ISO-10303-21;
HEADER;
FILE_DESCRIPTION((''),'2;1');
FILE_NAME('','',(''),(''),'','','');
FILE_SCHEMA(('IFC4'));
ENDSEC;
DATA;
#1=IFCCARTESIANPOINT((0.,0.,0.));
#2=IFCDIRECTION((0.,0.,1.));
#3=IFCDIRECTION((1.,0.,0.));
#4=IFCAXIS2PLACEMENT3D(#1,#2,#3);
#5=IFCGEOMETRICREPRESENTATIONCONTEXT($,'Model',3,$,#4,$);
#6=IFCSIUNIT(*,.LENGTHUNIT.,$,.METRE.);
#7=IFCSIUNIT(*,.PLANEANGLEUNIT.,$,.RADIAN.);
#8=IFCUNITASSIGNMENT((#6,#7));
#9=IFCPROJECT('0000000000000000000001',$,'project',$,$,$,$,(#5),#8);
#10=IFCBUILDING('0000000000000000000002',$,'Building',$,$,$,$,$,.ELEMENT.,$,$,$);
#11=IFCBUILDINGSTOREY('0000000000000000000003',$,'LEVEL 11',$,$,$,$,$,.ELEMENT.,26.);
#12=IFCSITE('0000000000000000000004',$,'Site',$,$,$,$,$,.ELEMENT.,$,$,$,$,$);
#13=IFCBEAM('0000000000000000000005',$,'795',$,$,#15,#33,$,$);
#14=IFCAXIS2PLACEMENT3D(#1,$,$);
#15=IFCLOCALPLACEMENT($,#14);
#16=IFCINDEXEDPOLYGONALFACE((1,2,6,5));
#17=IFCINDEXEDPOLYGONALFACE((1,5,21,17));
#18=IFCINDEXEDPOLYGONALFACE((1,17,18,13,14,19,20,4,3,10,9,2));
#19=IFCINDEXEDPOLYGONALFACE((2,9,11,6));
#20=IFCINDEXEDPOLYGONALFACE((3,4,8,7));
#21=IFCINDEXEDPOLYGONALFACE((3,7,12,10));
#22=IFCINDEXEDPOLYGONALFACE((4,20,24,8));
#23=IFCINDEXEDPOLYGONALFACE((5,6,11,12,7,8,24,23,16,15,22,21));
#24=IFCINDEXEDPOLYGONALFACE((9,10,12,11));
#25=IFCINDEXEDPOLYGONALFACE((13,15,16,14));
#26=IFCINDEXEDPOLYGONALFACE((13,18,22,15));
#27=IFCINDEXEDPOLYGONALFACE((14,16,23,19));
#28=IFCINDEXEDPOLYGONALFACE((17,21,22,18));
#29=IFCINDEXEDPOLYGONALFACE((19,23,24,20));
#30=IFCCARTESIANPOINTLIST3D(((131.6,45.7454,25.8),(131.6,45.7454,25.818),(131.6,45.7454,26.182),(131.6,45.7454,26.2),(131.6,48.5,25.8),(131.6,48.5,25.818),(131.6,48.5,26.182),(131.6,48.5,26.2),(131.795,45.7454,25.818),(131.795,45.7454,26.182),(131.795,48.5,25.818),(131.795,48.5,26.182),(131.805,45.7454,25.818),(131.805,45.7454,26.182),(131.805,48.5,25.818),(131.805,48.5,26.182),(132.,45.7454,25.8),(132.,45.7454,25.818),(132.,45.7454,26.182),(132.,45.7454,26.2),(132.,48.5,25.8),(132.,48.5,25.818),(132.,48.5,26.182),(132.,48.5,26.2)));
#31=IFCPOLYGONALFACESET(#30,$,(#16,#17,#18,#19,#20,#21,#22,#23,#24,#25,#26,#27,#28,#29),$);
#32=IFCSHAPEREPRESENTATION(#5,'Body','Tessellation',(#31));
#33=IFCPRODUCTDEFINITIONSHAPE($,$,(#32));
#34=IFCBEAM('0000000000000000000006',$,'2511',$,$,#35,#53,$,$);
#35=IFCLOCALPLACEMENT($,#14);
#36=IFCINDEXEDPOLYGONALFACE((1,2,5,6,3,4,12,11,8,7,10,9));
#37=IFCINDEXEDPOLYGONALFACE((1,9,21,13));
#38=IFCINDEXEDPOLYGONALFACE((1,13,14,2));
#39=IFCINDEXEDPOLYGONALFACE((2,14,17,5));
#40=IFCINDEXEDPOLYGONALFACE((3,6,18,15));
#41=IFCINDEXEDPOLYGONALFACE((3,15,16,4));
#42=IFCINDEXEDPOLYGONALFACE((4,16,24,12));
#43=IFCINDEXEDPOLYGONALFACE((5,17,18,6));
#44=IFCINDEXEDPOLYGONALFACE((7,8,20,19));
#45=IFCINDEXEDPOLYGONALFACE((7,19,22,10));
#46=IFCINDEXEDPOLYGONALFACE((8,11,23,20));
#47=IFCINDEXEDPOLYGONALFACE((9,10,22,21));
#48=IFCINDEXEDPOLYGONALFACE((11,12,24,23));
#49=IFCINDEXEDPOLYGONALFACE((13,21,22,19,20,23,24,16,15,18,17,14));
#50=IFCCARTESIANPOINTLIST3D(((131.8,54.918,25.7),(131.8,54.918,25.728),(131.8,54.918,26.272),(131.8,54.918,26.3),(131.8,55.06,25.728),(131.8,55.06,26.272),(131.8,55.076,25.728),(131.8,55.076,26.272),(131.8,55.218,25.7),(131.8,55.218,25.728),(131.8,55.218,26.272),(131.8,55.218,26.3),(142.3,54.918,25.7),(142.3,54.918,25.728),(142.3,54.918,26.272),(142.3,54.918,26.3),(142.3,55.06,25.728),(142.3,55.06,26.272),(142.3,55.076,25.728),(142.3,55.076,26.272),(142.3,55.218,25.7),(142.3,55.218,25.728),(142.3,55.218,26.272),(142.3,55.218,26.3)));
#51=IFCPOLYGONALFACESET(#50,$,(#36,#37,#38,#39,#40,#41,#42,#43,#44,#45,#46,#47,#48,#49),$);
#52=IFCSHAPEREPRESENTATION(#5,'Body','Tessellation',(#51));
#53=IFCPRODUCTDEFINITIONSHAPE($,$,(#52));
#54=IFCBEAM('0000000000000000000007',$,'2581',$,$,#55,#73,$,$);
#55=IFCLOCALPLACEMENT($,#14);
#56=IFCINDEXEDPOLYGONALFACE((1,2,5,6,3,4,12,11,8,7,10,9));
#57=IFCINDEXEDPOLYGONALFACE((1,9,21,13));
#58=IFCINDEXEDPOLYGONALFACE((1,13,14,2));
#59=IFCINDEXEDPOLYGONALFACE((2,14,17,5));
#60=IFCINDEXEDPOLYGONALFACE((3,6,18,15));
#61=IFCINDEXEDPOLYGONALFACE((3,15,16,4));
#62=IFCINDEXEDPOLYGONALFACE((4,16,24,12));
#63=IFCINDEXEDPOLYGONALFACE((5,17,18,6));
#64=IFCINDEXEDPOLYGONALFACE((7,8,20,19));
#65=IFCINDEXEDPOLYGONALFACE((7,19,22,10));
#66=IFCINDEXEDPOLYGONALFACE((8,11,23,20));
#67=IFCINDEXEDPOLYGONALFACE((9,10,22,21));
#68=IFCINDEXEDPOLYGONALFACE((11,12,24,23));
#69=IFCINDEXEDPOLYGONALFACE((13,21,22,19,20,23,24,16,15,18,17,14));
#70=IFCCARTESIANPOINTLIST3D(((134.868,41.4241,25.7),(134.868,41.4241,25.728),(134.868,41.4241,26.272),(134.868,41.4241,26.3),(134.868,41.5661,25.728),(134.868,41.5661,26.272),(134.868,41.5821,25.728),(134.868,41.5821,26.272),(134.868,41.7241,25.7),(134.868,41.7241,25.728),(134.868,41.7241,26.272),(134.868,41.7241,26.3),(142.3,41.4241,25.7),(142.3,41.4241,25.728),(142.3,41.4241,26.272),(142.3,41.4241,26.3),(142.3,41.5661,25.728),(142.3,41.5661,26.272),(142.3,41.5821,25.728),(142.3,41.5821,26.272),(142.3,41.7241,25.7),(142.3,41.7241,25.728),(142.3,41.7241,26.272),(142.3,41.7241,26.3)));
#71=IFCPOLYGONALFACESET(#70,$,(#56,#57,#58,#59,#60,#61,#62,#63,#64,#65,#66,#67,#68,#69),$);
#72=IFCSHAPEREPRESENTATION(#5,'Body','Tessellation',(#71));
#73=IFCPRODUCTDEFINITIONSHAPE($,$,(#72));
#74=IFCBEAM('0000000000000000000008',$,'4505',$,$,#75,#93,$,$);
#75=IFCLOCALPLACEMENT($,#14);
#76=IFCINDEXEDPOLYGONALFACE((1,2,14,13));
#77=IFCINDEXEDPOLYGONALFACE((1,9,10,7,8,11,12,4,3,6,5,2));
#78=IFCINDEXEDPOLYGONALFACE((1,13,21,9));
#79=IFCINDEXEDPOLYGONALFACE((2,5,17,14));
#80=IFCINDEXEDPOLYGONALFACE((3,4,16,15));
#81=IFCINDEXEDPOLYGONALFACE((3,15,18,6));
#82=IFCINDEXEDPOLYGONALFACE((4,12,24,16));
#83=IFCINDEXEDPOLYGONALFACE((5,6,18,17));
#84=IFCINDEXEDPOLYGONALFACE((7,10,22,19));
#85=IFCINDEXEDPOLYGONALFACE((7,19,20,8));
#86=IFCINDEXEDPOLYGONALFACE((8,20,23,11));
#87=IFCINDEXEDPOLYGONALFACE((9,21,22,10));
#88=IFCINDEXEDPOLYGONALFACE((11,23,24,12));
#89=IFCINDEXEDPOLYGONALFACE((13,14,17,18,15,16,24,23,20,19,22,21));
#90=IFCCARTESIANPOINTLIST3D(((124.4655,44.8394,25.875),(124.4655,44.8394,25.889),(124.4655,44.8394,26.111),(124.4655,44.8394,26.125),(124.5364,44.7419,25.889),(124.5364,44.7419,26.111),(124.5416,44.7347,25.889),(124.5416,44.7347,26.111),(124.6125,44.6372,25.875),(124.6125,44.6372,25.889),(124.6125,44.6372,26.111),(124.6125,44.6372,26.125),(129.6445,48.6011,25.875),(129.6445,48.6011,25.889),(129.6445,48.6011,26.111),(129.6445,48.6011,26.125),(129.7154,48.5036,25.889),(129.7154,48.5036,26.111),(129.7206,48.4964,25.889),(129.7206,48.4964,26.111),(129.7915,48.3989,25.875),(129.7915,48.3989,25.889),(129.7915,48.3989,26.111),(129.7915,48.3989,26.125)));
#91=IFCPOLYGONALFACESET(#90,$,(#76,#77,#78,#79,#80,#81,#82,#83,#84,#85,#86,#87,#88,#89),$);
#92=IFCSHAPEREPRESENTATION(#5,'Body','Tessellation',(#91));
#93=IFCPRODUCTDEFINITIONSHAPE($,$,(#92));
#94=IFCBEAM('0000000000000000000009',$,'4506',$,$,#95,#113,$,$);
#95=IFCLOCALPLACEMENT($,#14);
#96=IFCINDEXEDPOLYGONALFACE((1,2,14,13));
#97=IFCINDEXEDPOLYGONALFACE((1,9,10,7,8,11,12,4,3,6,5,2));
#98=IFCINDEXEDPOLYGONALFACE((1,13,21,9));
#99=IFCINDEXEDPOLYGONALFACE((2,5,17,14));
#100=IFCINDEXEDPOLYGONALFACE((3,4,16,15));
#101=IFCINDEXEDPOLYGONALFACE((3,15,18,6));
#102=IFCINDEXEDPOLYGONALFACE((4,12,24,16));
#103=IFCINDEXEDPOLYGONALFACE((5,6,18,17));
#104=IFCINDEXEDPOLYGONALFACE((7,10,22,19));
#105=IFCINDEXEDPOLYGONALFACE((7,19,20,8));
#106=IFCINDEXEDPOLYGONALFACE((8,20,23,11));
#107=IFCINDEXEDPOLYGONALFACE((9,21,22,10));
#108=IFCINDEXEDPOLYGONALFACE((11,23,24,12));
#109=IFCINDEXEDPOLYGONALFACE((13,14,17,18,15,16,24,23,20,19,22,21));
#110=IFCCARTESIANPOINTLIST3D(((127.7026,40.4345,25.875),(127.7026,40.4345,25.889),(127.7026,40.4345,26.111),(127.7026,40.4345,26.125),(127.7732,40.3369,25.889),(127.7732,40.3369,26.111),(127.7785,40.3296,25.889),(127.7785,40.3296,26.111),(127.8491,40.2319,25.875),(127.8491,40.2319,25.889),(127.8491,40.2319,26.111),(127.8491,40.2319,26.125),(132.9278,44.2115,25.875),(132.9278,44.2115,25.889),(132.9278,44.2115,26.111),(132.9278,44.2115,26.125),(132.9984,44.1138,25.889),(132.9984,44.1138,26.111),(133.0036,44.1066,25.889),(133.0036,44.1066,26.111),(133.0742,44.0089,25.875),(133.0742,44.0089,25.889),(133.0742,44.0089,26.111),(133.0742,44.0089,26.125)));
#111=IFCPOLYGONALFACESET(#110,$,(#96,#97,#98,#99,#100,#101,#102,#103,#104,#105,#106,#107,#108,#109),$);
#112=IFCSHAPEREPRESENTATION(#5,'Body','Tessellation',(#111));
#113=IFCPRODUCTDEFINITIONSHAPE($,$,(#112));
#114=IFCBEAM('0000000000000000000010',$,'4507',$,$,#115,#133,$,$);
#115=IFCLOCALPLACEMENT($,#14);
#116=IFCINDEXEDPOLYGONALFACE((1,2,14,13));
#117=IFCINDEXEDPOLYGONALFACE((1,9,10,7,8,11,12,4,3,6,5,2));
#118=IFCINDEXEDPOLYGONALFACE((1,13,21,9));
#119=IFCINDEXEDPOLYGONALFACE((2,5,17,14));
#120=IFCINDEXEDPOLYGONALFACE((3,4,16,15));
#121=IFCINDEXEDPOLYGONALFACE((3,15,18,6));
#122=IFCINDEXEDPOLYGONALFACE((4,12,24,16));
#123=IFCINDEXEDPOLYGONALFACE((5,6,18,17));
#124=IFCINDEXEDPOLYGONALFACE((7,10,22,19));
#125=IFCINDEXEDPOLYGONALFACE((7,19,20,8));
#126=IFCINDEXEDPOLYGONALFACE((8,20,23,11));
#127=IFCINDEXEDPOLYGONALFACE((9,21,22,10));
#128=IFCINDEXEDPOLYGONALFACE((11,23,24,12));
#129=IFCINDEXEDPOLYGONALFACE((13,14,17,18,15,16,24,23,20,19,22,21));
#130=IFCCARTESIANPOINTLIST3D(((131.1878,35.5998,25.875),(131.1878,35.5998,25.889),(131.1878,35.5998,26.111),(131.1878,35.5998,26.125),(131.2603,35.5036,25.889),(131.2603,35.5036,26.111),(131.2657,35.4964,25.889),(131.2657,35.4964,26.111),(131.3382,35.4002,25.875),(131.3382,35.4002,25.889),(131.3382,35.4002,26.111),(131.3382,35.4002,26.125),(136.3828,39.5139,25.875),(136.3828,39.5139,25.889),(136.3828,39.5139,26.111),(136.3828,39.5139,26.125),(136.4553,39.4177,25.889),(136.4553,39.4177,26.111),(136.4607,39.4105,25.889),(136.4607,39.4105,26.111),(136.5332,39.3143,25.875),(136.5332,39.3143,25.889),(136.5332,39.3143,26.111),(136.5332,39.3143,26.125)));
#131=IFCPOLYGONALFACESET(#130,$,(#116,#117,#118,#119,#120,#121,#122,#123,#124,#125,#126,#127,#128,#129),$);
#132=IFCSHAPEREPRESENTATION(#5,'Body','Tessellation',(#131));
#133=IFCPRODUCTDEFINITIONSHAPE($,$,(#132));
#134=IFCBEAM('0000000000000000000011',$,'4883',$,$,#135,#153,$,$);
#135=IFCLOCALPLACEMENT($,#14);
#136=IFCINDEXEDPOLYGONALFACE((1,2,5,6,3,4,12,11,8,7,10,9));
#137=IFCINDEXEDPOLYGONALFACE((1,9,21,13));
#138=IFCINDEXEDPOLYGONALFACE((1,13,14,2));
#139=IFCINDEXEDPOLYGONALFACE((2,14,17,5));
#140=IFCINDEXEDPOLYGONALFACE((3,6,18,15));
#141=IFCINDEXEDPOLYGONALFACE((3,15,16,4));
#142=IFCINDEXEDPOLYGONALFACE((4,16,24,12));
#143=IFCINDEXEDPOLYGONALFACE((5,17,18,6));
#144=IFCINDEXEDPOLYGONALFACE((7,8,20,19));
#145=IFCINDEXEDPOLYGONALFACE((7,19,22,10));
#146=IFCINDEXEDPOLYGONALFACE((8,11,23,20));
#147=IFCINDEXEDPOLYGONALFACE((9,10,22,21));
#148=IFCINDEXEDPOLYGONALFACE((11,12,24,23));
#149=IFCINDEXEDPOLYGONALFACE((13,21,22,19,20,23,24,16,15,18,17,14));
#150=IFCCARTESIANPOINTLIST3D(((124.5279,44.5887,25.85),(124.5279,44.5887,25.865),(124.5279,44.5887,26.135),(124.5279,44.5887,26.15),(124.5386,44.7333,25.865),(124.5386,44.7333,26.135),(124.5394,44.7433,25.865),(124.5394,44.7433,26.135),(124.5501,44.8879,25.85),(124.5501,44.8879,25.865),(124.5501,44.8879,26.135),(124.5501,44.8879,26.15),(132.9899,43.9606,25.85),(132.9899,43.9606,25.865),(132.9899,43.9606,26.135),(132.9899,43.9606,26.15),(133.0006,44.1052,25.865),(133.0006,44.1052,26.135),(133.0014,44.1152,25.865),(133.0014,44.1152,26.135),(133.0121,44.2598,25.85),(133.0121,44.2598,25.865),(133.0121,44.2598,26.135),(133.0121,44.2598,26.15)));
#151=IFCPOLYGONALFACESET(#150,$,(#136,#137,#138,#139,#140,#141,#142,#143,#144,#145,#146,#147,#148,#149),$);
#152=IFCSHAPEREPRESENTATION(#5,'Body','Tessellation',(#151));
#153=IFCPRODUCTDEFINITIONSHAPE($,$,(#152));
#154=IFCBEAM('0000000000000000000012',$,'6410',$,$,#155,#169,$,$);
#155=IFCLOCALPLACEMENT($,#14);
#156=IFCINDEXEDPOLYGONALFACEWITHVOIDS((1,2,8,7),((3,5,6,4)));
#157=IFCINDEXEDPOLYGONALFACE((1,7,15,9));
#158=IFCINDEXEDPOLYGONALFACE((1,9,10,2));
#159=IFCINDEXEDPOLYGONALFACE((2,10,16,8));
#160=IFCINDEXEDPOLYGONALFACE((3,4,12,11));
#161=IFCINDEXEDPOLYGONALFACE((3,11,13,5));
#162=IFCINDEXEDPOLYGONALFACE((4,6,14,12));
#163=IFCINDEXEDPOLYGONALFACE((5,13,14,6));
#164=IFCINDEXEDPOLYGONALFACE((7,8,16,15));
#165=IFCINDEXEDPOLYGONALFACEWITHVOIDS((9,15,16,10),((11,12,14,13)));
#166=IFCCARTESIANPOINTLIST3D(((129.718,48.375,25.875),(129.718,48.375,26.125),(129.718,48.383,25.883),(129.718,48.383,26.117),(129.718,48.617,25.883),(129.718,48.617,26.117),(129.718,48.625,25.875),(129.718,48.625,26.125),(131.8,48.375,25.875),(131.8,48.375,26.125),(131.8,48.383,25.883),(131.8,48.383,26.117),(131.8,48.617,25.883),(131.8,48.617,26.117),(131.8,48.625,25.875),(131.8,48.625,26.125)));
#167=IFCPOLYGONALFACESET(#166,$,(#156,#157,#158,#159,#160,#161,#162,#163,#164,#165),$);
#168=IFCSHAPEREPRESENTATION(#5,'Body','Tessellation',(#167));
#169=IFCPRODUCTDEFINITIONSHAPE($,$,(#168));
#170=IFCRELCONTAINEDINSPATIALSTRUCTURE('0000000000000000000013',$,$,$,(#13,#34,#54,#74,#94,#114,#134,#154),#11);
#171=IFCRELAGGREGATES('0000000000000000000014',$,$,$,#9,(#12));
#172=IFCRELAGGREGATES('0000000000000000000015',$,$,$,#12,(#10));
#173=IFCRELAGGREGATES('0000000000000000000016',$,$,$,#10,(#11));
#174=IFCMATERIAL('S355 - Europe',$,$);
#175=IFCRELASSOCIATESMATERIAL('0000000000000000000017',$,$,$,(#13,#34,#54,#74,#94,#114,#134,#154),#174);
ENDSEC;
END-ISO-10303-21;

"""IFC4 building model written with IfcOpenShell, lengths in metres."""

from ifc_helpers import new_model, si_unit, frame, origin_with_axes, origin_2d_with_axis, place, context, project, spatial, hollow_rectangle, i_section, extrude, material, material_profile, profile_set, profile_usage, element, save


model = new_model("IFC4")

# Units and contexts
model_context = context("Model", 3, world=origin_with_axes())
ifc_project = project(units=[si_unit("LENGTHUNIT", "METRE"), si_unit("PLANEANGLEUNIT", "RADIAN")], contexts=[model_context])

# Site, building, storey
site = spatial("IfcSite", under=ifc_project, Name="Site", CompositionType="ELEMENT")
building = spatial("IfcBuilding", under=site, Name="Building", CompositionType="ELEMENT")
storey = spatial("IfcBuildingStorey", under=building, Name="LEVEL 11", CompositionType="ELEMENT", Elevation=26.0)

# Shared definitions
ifc_material = material(Name="S355 - Europe")

# Beams
ifc_material_profile_1 = material_profile(ifc_material, i_section(OverallWidth=0.4, OverallDepth=0.4, WebThickness=0.01, FlangeThickness=0.018, at=origin_2d_with_axis()))
ifc_profile_set_1 = profile_set([ifc_material_profile_1])
ifc_profile_usage_1 = profile_usage(ifc_profile_set_1, cardinal=10)
beam_1_placement = place(None, frame((131.8, 45.7454, 26.0), z_axis=(0.0, 1.0, 0.0), x_axis=(-1.0, 0.0, 0.0)))
element("IfcBeam", 1, at=beam_1_placement, inside=storey, material=ifc_profile_usage_1, Name="795", context=model_context, shape_type="SweptSolid", body=[
    extrude(i_section(OverallWidth=0.4, OverallDepth=0.4, WebThickness=0.01, FlangeThickness=0.018, at=origin_2d_with_axis()), origin_with_axes(), (0.0, 0.0, 1.0), 2.7546),
])
ifc_material_profile_2 = material_profile(ifc_material, i_section(OverallWidth=0.3, OverallDepth=0.6, WebThickness=0.016, FlangeThickness=0.028, at=origin_2d_with_axis()))
ifc_profile_set_2 = profile_set([ifc_material_profile_2])
ifc_profile_usage_2 = profile_usage(ifc_profile_set_2, cardinal=10)
beam_2_placement = place(None, frame((131.8, 55.068, 26.0), z_axis=(1.0, 0.0, 0.0), x_axis=(0.0, 1.0, 0.0)))
element("IfcBeam", 2, at=beam_2_placement, inside=storey, material=ifc_profile_usage_2, Name="2511", context=model_context, shape_type="SweptSolid", body=[
    extrude(i_section(OverallWidth=0.3, OverallDepth=0.6, WebThickness=0.016, FlangeThickness=0.028, at=origin_2d_with_axis()), origin_with_axes(), (0.0, 0.0, 1.0), 10.5),
])
ifc_material_profile_3 = material_profile(ifc_material, i_section(OverallWidth=0.3, OverallDepth=0.6, WebThickness=0.016, FlangeThickness=0.028, at=origin_2d_with_axis()))
ifc_profile_set_3 = profile_set([ifc_material_profile_3])
ifc_profile_usage_3 = profile_usage(ifc_profile_set_3, cardinal=10)
beam_3_placement = place(None, frame((134.868, 41.5741, 26.0), z_axis=(1.0, 0.0, 0.0), x_axis=(0.0, 1.0, 0.0)))
element("IfcBeam", 3, at=beam_3_placement, inside=storey, material=ifc_profile_usage_3, Name="2581", context=model_context, shape_type="SweptSolid", body=[
    extrude(i_section(OverallWidth=0.3, OverallDepth=0.6, WebThickness=0.016, FlangeThickness=0.028, at=origin_2d_with_axis()), origin_with_axes(), (0.0, 0.0, 1.0), 7.432),
])
ifc_material_profile_4 = material_profile(ifc_material, i_section(OverallWidth=0.25, OverallDepth=0.25, WebThickness=0.009, FlangeThickness=0.014, at=origin_2d_with_axis()))
ifc_profile_set_4 = profile_set([ifc_material_profile_4])
ifc_profile_usage_4 = profile_usage(ifc_profile_set_4, cardinal=10)
beam_4_placement = place(None, frame((129.718, 48.5, 26.0), z_axis=(-0.809096, -0.587676, 0.0), x_axis=(0.587676, -0.809096, 0.0)))
element("IfcBeam", 4, at=beam_4_placement, inside=storey, material=ifc_profile_usage_4, Name="4505", context=model_context, shape_type="SweptSolid", body=[
    extrude(i_section(OverallWidth=0.25, OverallDepth=0.25, WebThickness=0.009, FlangeThickness=0.014, at=origin_2d_with_axis()), origin_with_axes(), (0.0, 0.0, 1.0), 6.401),
])
ifc_material_profile_5 = material_profile(ifc_material, i_section(OverallWidth=0.25, OverallDepth=0.25, WebThickness=0.009, FlangeThickness=0.014, at=origin_2d_with_axis()))
ifc_profile_set_5 = profile_set([ifc_material_profile_5])
ifc_profile_usage_5 = profile_usage(ifc_profile_set_5, cardinal=10)
beam_5_placement = place(None, frame((133.001, 44.1102, 26.0), z_axis=(-0.810441, -0.585821, 0.0), x_axis=(0.585821, -0.810441, 0.0)))
element("IfcBeam", 5, at=beam_5_placement, inside=storey, material=ifc_profile_usage_5, Name="4506", context=model_context, shape_type="SweptSolid", body=[
    extrude(i_section(OverallWidth=0.25, OverallDepth=0.25, WebThickness=0.009, FlangeThickness=0.014, at=origin_2d_with_axis()), origin_with_axes(), (0.0, 0.0, 1.0), 6.4473),
])
ifc_material_profile_6 = material_profile(ifc_material, i_section(OverallWidth=0.25, OverallDepth=0.25, WebThickness=0.009, FlangeThickness=0.014, at=origin_2d_with_axis()))
ifc_profile_set_6 = profile_set([ifc_material_profile_6])
ifc_profile_usage_6 = profile_usage(ifc_profile_set_6, cardinal=10)
beam_6_placement = place(None, frame((136.458, 39.4141, 26.0), z_axis=(-0.798681, -0.601755, 0.0), x_axis=(0.601755, -0.798681, 0.0)))
element("IfcBeam", 6, at=beam_6_placement, inside=storey, material=ifc_profile_usage_6, Name="4507", context=model_context, shape_type="SweptSolid", body=[
    extrude(i_section(OverallWidth=0.25, OverallDepth=0.25, WebThickness=0.009, FlangeThickness=0.014, at=origin_2d_with_axis()), origin_with_axes(), (0.0, 0.0, 1.0), 6.5045),
])
ifc_material_profile_7 = material_profile(ifc_material, i_section(OverallWidth=0.3, OverallDepth=0.3, WebThickness=0.01, FlangeThickness=0.015, at=origin_2d_with_axis()))
ifc_profile_set_7 = profile_set([ifc_material_profile_7])
ifc_profile_usage_7 = profile_usage(ifc_profile_set_7, cardinal=10)
beam_7_placement = place(None, frame((133.001, 44.1102, 26.0), z_axis=(-0.997257, 0.074022, 0.0), x_axis=(-0.074022, -0.997257, 0.0)))
element("IfcBeam", 7, at=beam_7_placement, inside=storey, material=ifc_profile_usage_7, Name="4883", context=model_context, shape_type="SweptSolid", body=[
    extrude(i_section(OverallWidth=0.3, OverallDepth=0.3, WebThickness=0.01, FlangeThickness=0.015, at=origin_2d_with_axis()), origin_with_axes(), (0.0, 0.0, 1.0), 8.4853),
])
ifc_material_profile_8 = material_profile(ifc_material, hollow_rectangle(XDim=0.25, YDim=0.25, WallThickness=0.008, at=origin_2d_with_axis()))
ifc_profile_set_8 = profile_set([ifc_material_profile_8])
ifc_profile_usage_8 = profile_usage(ifc_profile_set_8, cardinal=10)
beam_8_placement = place(None, frame((129.718, 48.5, 26.0), z_axis=(1.0, 0.0, 0.0), x_axis=(0.0, 1.0, 0.0)))
element("IfcBeam", 8, at=beam_8_placement, inside=storey, material=ifc_profile_usage_8, Name="6410", context=model_context, shape_type="SweptSolid", body=[
    extrude(hollow_rectangle(XDim=0.25, YDim=0.25, WallThickness=0.008, at=origin_2d_with_axis()), origin_with_axes(), (0.0, 0.0, 1.0), 2.082),
])

save(model, "model.ifc")
